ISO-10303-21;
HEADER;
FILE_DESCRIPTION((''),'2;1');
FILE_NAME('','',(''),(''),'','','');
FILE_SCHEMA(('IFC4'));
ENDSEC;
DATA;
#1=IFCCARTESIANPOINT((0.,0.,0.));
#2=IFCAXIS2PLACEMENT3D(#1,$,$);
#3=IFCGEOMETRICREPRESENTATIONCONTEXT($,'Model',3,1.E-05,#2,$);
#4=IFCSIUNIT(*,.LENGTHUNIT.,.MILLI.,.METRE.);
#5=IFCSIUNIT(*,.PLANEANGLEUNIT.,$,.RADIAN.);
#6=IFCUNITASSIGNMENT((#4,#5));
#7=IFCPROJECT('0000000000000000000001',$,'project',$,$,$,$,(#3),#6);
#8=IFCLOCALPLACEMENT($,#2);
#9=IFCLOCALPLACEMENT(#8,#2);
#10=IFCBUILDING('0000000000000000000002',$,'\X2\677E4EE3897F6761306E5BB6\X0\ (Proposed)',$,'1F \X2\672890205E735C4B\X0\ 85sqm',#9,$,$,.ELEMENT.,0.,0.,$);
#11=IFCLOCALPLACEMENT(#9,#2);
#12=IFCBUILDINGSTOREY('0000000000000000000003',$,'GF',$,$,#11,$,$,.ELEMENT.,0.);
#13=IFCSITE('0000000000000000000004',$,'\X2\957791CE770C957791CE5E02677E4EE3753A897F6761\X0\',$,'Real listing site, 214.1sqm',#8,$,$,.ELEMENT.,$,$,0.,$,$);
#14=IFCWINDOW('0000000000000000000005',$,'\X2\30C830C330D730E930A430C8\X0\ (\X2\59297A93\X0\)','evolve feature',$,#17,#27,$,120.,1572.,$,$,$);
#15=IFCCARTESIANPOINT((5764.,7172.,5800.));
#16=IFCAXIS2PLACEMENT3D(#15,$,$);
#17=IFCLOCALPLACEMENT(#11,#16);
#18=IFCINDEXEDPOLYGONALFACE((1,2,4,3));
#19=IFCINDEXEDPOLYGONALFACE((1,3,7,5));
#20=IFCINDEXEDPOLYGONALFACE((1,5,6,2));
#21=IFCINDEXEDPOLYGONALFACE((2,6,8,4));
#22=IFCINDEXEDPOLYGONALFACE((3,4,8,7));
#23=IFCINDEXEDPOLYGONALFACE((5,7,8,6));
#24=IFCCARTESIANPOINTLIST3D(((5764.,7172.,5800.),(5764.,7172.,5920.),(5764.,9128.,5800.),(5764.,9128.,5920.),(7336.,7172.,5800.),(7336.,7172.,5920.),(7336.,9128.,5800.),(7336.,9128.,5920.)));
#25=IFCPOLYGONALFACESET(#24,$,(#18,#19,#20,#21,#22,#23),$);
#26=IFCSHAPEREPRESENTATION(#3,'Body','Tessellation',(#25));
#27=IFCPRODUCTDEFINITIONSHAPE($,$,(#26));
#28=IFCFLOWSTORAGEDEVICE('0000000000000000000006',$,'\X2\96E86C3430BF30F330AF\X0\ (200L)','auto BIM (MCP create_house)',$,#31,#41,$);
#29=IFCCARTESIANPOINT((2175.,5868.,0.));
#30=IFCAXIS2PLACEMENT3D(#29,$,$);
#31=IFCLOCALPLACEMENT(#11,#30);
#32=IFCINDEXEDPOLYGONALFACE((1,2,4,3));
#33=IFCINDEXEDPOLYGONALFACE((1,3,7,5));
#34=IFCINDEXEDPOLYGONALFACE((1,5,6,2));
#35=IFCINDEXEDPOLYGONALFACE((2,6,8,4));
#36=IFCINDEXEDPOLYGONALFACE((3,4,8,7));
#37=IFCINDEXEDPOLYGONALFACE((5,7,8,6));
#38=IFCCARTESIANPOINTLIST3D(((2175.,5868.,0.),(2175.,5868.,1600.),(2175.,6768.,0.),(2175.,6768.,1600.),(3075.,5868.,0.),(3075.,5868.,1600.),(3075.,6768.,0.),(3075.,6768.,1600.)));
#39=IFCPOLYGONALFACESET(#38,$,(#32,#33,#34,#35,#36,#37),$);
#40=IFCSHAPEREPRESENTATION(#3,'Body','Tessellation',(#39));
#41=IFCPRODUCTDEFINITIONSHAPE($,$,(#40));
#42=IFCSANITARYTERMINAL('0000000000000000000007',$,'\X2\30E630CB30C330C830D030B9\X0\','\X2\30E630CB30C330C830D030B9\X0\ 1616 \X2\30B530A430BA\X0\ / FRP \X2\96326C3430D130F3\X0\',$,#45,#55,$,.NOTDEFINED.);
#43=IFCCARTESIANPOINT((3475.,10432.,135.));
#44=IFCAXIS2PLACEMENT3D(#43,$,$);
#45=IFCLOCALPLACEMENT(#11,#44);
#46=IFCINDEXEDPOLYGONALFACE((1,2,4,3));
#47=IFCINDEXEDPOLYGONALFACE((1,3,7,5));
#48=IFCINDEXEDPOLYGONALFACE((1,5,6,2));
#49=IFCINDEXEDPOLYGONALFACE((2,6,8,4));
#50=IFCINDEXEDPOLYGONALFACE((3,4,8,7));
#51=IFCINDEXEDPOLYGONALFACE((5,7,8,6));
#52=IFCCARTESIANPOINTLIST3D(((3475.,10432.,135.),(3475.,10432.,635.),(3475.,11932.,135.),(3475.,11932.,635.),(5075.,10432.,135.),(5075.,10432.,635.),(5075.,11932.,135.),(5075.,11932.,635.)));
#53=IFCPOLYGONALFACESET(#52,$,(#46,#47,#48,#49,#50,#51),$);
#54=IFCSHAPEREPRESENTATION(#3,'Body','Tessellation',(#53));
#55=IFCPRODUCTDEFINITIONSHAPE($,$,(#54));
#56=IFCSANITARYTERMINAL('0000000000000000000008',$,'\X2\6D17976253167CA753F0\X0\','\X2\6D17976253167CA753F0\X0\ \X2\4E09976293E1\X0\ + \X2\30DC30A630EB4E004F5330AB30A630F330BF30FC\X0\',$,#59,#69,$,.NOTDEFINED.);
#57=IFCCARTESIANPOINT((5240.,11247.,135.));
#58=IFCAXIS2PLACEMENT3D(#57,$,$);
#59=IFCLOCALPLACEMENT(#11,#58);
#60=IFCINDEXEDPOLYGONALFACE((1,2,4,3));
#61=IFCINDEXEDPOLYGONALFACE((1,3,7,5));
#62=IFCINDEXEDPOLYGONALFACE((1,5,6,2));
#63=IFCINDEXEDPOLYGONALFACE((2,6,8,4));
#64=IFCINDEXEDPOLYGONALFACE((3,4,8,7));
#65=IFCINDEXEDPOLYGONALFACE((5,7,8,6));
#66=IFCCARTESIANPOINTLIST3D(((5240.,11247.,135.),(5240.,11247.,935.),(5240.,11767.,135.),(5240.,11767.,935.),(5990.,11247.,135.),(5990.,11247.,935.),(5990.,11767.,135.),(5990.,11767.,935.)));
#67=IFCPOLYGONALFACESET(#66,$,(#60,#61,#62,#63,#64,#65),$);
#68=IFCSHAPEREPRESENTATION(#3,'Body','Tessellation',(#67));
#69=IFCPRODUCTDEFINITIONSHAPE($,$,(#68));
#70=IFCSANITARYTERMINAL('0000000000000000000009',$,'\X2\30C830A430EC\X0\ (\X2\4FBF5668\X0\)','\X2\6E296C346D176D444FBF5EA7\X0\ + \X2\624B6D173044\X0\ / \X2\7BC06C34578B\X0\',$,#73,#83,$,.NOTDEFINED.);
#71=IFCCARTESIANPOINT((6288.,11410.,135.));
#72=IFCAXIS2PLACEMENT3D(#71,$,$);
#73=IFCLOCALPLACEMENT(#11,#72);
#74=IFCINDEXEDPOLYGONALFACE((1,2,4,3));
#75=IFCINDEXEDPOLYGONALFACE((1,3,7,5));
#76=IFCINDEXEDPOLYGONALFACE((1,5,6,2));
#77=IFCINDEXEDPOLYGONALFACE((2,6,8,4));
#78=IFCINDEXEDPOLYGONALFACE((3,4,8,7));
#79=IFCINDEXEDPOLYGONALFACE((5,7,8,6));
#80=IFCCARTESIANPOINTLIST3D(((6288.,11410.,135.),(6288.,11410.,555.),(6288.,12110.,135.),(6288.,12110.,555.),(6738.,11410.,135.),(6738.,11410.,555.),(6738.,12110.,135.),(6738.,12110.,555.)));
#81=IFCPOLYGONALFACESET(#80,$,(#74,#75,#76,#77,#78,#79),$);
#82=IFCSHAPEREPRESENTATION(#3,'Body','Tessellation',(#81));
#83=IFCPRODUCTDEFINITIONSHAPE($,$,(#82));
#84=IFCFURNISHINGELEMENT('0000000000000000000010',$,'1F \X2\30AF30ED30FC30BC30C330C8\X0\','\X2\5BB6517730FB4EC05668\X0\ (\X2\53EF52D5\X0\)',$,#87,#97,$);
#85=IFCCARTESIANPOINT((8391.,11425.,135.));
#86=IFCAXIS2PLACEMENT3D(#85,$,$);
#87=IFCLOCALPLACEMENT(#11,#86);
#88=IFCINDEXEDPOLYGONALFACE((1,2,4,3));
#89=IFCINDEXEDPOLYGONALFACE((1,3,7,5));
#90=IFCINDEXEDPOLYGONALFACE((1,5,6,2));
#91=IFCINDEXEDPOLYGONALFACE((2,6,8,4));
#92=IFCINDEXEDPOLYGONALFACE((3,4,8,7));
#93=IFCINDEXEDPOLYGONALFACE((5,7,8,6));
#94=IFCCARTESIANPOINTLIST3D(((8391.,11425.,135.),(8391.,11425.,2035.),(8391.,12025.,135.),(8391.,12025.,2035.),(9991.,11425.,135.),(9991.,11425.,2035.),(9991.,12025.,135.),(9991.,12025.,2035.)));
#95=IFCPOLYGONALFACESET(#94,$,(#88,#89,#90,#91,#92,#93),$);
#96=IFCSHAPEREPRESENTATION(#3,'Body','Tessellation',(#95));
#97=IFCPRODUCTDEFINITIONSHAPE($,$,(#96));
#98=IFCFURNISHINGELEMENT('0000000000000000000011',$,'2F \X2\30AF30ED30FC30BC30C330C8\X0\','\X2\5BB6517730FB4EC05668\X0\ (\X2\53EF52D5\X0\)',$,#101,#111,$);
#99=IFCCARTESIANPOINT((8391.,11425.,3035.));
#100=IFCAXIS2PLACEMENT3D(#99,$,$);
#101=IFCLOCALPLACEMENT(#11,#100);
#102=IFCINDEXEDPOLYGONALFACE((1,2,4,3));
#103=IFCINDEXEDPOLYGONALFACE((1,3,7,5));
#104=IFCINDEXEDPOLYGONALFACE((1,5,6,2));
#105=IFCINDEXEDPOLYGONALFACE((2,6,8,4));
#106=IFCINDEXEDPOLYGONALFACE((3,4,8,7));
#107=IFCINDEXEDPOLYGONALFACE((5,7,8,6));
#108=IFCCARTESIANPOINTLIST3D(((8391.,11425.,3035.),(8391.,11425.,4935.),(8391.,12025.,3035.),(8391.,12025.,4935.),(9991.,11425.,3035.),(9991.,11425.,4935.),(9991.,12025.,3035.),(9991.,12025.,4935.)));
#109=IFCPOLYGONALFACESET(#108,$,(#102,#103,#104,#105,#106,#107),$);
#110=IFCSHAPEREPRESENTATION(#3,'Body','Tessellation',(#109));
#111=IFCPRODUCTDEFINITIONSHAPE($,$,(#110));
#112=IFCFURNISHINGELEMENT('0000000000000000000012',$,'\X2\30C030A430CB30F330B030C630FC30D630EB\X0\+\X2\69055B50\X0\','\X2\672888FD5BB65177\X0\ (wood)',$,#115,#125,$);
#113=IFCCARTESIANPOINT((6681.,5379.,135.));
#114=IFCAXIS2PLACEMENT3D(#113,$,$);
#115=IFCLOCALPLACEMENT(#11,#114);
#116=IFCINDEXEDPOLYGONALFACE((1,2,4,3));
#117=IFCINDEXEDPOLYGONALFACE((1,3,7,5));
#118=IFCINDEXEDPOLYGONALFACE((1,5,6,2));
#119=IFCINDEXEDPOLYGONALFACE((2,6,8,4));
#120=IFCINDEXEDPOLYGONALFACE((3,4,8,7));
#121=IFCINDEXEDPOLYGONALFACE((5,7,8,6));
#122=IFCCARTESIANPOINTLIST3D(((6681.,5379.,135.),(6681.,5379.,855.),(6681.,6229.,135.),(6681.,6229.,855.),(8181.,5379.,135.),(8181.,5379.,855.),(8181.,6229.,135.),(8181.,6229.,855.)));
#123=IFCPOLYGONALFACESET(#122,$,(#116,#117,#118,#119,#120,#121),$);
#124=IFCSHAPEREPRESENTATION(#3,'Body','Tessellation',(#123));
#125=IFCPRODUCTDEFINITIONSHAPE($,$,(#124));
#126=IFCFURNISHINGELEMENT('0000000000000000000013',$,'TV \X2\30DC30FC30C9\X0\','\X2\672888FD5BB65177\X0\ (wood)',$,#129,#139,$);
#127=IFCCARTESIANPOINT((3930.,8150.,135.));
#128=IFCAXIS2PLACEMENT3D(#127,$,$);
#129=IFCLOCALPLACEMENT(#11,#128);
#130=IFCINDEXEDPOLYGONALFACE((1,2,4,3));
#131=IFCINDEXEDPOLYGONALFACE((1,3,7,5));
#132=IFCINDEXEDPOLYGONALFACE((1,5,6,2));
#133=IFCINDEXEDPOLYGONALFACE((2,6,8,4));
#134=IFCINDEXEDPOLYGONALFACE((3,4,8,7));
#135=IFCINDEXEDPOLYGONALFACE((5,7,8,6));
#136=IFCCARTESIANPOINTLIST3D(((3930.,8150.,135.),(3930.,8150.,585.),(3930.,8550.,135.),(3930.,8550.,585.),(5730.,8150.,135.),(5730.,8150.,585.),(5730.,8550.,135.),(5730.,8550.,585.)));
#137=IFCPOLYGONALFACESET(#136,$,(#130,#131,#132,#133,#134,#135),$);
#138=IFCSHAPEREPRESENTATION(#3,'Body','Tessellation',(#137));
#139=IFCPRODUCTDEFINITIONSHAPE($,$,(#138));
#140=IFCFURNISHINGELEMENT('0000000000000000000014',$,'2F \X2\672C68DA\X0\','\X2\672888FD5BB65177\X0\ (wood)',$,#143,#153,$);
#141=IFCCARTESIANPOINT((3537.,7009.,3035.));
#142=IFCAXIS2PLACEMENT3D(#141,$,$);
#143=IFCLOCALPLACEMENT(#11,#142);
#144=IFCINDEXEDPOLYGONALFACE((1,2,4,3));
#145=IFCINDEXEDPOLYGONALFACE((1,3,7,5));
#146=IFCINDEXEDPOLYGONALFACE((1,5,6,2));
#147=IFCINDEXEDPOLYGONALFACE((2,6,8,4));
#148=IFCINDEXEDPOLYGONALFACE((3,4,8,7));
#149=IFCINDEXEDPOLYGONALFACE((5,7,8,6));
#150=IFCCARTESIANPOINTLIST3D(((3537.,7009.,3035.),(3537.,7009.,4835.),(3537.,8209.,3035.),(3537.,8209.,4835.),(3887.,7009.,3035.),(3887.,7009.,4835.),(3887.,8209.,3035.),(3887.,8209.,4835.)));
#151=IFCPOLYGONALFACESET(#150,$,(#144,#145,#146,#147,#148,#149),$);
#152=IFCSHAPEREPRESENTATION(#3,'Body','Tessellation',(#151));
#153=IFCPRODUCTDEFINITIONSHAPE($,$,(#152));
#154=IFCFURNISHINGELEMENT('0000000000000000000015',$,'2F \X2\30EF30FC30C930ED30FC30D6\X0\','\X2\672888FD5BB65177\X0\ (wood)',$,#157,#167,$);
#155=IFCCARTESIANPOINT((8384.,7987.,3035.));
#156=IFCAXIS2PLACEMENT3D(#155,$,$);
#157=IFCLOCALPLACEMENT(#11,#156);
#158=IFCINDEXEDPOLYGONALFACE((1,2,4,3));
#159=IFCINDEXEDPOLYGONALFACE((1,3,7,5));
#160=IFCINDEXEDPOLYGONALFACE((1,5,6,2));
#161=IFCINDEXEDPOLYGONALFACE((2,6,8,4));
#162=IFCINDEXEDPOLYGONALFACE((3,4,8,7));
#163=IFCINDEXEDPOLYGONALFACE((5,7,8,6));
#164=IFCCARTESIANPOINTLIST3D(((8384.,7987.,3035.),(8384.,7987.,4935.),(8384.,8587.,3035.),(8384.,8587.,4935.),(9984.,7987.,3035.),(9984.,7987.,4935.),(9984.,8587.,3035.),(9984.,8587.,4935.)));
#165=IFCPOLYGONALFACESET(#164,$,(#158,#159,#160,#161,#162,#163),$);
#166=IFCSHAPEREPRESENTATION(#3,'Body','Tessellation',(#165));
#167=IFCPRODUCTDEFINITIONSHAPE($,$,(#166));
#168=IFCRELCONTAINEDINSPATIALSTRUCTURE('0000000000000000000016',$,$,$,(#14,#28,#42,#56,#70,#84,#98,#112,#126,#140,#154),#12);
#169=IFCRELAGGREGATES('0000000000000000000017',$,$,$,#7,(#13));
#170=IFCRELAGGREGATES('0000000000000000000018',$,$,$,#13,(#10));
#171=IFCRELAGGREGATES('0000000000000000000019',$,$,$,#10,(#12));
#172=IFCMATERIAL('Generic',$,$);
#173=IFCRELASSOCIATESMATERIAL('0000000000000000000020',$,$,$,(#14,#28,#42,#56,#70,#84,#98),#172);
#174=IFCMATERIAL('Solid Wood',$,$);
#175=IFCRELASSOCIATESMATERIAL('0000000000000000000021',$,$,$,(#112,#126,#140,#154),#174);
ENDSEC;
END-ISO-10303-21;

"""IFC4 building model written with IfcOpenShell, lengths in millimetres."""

from ifc_helpers import new_model, si_unit, frame, frame_2d, origin, place, context, project, spatial, rectangle, extrude, material, element, save


model = new_model("IFC4")

# Units and contexts
model_context = context("Model", 3, precision=1e-05, world=origin())
ifc_project = project(units=[si_unit("LENGTHUNIT", "METRE", prefix="MILLI"), si_unit("PLANEANGLEUNIT", "RADIAN")], contexts=[model_context])

# Site, building, storey
site_placement = place(None, origin())
site = spatial("IfcSite", under=ifc_project, at=site_placement, Name="長野県長野市松代町西条", ObjectType="Real listing site, 214.1sqm", CompositionType="ELEMENT", RefElevation=0.0)
building_placement = place(site_placement, origin())
building = spatial("IfcBuilding", under=site, at=building_placement, Name="松代西条の家 (Proposed)", ObjectType="1F 木造平屋 85sqm", CompositionType="ELEMENT", ElevationOfRefHeight=0.0, ElevationOfTerrain=0.0)
storey_placement = place(building_placement, origin())
storey = spatial("IfcBuildingStorey", under=building, at=storey_placement, Name="GF", CompositionType="ELEMENT", Elevation=0.0)

# Shared definitions
ifc_material_1 = material(Name="Solid Wood")

# Window
ifc_material_2 = material(Name="Generic")
window_1_placement = place(storey_placement, frame((5764.0, 7172.0, 5800.0)))
element("IfcWindow", 1, at=window_1_placement, inside=storey, material=ifc_material_2, Name="トップライト (天窓)", Description="evolve feature", OverallHeight=120.0, OverallWidth=1572.0, context=model_context, shape_type="SweptSolid", body=[
    extrude(rectangle(XDim=1572.0, YDim=1956.0, at=frame_2d((786.0, 978.0))), frame((5764.0, 7172.0, 5800.0)), (0.0, 0.0, 1.0), 120.0),
])

# Flow storage device
flow_storage_device_placement = place(storey_placement, frame((2175.0, 5868.0, 0.0)))
element("IfcFlowStorageDevice", 2, at=flow_storage_device_placement, inside=storey, material=ifc_material_2, Name="雨水タンク (200L)", Description="auto BIM (MCP create_house)", context=model_context, shape_type="SweptSolid", body=[
    extrude(rectangle(XDim=900.0, YDim=900.0, at=frame_2d((450.0, 450.0))), frame((2175.0, 5868.0, 0.0)), (0.0, 0.0, 1.0), 1600.0),
])

# Sanitary terminals
sanitary_terminal_1_placement = place(storey_placement, frame((3475.0, 10432.0, 135.0)))
element("IfcSanitaryTerminal", 3, at=sanitary_terminal_1_placement, inside=storey, material=ifc_material_2, Name="ユニットバス", Description="ユニットバス 1616 サイズ / FRP 防水パン", PredefinedType="NOTDEFINED", context=model_context, shape_type="SweptSolid", body=[
    extrude(rectangle(XDim=1600.0, YDim=1500.0, at=frame_2d((800.0, 750.0))), frame((3475.0, 10432.0, 135.0)), (0.0, 0.0, 1.0), 500.0),
])
sanitary_terminal_2_placement = place(storey_placement, frame((5240.0, 11247.0, 135.0)))
element("IfcSanitaryTerminal", 4, at=sanitary_terminal_2_placement, inside=storey, material=ifc_material_2, Name="洗面化粧台", Description="洗面化粧台 三面鏡 + ボウル一体カウンター", PredefinedType="NOTDEFINED", context=model_context, shape_type="SweptSolid", body=[
    extrude(rectangle(XDim=750.0, YDim=520.0, at=frame_2d((375.0, 260.0))), frame((5240.0, 11247.0, 135.0)), (0.0, 0.0, 1.0), 800.0),
])
sanitary_terminal_3_placement = place(storey_placement, frame((6288.0, 11410.0, 135.0)))
element("IfcSanitaryTerminal", 5, at=sanitary_terminal_3_placement, inside=storey, material=ifc_material_2, Name="トイレ (便器)", Description="温水洗浄便座 + 手洗い / 節水型", PredefinedType="NOTDEFINED", context=model_context, shape_type="SweptSolid", body=[
    extrude(rectangle(XDim=450.0, YDim=700.0, at=frame_2d((225.0, 350.0))), frame((6288.0, 11410.0, 135.0)), (0.0, 0.0, 1.0), 420.0),
])

# Furnishing elements
furnishing_1_placement = place(storey_placement, frame((8391.0, 11425.0, 135.0)))
element("IfcFurnishingElement", 6, at=furnishing_1_placement, inside=storey, material=ifc_material_2, Name="1F クローゼット", Description="家具・什器 (可動)", context=model_context, shape_type="SweptSolid", body=[
    extrude(rectangle(XDim=1600.0, YDim=600.0, at=frame_2d((800.0, 300.0))), frame((8391.0, 11425.0, 135.0)), (0.0, 0.0, 1.0), 1900.0),
])
furnishing_2_placement = place(storey_placement, frame((8391.0, 11425.0, 3035.0)))
element("IfcFurnishingElement", 7, at=furnishing_2_placement, inside=storey, material=ifc_material_2, Name="2F クローゼット", Description="家具・什器 (可動)", context=model_context, shape_type="SweptSolid", body=[
    extrude(rectangle(XDim=1600.0, YDim=600.0, at=frame_2d((800.0, 300.0))), frame((8391.0, 11425.0, 3035.0)), (0.0, 0.0, 1.0), 1900.0),
])
furnishing_3_placement = place(storey_placement, frame((6681.0, 5379.0, 135.0)))
element("IfcFurnishingElement", 8, at=furnishing_3_placement, inside=storey, material=ifc_material_1, Name="ダイニングテーブル+椅子", Description="木製家具 (wood)", context=model_context, shape_type="SweptSolid", body=[
    extrude(rectangle(XDim=1500.0, YDim=850.0, at=frame_2d((750.0, 425.0))), frame((6681.0, 5379.0, 135.0)), (0.0, 0.0, 1.0), 720.0),
])
furnishing_4_placement = place(storey_placement, frame((3930.0, 8150.0, 135.0)))
element("IfcFurnishingElement", 9, at=furnishing_4_placement, inside=storey, material=ifc_material_1, Name="TV ボード", Description="木製家具 (wood)", context=model_context, shape_type="SweptSolid", body=[
    extrude(rectangle(XDim=1800.0, YDim=400.0, at=frame_2d((900.0, 200.0))), frame((3930.0, 8150.0, 135.0)), (0.0, 0.0, 1.0), 450.0),
])
furnishing_5_placement = place(storey_placement, frame((3537.0, 7009.0, 3035.0)))
element("IfcFurnishingElement", 10, at=furnishing_5_placement, inside=storey, material=ifc_material_1, Name="2F 本棚", Description="木製家具 (wood)", context=model_context, shape_type="SweptSolid", body=[
    extrude(rectangle(XDim=350.0, YDim=1200.0, at=frame_2d((175.0, 600.0))), frame((3537.0, 7009.0, 3035.0)), (0.0, 0.0, 1.0), 1800.0),
])
furnishing_6_placement = place(storey_placement, frame((8384.0, 7987.0, 3035.0)))
element("IfcFurnishingElement", 11, at=furnishing_6_placement, inside=storey, material=ifc_material_1, Name="2F ワードローブ", Description="木製家具 (wood)", context=model_context, shape_type="SweptSolid", body=[
    extrude(rectangle(XDim=1600.0, YDim=600.0, at=frame_2d((800.0, 300.0))), frame((8384.0, 7987.0, 3035.0)), (0.0, 0.0, 1.0), 1900.0),
])

save(model, "model.ifc")
